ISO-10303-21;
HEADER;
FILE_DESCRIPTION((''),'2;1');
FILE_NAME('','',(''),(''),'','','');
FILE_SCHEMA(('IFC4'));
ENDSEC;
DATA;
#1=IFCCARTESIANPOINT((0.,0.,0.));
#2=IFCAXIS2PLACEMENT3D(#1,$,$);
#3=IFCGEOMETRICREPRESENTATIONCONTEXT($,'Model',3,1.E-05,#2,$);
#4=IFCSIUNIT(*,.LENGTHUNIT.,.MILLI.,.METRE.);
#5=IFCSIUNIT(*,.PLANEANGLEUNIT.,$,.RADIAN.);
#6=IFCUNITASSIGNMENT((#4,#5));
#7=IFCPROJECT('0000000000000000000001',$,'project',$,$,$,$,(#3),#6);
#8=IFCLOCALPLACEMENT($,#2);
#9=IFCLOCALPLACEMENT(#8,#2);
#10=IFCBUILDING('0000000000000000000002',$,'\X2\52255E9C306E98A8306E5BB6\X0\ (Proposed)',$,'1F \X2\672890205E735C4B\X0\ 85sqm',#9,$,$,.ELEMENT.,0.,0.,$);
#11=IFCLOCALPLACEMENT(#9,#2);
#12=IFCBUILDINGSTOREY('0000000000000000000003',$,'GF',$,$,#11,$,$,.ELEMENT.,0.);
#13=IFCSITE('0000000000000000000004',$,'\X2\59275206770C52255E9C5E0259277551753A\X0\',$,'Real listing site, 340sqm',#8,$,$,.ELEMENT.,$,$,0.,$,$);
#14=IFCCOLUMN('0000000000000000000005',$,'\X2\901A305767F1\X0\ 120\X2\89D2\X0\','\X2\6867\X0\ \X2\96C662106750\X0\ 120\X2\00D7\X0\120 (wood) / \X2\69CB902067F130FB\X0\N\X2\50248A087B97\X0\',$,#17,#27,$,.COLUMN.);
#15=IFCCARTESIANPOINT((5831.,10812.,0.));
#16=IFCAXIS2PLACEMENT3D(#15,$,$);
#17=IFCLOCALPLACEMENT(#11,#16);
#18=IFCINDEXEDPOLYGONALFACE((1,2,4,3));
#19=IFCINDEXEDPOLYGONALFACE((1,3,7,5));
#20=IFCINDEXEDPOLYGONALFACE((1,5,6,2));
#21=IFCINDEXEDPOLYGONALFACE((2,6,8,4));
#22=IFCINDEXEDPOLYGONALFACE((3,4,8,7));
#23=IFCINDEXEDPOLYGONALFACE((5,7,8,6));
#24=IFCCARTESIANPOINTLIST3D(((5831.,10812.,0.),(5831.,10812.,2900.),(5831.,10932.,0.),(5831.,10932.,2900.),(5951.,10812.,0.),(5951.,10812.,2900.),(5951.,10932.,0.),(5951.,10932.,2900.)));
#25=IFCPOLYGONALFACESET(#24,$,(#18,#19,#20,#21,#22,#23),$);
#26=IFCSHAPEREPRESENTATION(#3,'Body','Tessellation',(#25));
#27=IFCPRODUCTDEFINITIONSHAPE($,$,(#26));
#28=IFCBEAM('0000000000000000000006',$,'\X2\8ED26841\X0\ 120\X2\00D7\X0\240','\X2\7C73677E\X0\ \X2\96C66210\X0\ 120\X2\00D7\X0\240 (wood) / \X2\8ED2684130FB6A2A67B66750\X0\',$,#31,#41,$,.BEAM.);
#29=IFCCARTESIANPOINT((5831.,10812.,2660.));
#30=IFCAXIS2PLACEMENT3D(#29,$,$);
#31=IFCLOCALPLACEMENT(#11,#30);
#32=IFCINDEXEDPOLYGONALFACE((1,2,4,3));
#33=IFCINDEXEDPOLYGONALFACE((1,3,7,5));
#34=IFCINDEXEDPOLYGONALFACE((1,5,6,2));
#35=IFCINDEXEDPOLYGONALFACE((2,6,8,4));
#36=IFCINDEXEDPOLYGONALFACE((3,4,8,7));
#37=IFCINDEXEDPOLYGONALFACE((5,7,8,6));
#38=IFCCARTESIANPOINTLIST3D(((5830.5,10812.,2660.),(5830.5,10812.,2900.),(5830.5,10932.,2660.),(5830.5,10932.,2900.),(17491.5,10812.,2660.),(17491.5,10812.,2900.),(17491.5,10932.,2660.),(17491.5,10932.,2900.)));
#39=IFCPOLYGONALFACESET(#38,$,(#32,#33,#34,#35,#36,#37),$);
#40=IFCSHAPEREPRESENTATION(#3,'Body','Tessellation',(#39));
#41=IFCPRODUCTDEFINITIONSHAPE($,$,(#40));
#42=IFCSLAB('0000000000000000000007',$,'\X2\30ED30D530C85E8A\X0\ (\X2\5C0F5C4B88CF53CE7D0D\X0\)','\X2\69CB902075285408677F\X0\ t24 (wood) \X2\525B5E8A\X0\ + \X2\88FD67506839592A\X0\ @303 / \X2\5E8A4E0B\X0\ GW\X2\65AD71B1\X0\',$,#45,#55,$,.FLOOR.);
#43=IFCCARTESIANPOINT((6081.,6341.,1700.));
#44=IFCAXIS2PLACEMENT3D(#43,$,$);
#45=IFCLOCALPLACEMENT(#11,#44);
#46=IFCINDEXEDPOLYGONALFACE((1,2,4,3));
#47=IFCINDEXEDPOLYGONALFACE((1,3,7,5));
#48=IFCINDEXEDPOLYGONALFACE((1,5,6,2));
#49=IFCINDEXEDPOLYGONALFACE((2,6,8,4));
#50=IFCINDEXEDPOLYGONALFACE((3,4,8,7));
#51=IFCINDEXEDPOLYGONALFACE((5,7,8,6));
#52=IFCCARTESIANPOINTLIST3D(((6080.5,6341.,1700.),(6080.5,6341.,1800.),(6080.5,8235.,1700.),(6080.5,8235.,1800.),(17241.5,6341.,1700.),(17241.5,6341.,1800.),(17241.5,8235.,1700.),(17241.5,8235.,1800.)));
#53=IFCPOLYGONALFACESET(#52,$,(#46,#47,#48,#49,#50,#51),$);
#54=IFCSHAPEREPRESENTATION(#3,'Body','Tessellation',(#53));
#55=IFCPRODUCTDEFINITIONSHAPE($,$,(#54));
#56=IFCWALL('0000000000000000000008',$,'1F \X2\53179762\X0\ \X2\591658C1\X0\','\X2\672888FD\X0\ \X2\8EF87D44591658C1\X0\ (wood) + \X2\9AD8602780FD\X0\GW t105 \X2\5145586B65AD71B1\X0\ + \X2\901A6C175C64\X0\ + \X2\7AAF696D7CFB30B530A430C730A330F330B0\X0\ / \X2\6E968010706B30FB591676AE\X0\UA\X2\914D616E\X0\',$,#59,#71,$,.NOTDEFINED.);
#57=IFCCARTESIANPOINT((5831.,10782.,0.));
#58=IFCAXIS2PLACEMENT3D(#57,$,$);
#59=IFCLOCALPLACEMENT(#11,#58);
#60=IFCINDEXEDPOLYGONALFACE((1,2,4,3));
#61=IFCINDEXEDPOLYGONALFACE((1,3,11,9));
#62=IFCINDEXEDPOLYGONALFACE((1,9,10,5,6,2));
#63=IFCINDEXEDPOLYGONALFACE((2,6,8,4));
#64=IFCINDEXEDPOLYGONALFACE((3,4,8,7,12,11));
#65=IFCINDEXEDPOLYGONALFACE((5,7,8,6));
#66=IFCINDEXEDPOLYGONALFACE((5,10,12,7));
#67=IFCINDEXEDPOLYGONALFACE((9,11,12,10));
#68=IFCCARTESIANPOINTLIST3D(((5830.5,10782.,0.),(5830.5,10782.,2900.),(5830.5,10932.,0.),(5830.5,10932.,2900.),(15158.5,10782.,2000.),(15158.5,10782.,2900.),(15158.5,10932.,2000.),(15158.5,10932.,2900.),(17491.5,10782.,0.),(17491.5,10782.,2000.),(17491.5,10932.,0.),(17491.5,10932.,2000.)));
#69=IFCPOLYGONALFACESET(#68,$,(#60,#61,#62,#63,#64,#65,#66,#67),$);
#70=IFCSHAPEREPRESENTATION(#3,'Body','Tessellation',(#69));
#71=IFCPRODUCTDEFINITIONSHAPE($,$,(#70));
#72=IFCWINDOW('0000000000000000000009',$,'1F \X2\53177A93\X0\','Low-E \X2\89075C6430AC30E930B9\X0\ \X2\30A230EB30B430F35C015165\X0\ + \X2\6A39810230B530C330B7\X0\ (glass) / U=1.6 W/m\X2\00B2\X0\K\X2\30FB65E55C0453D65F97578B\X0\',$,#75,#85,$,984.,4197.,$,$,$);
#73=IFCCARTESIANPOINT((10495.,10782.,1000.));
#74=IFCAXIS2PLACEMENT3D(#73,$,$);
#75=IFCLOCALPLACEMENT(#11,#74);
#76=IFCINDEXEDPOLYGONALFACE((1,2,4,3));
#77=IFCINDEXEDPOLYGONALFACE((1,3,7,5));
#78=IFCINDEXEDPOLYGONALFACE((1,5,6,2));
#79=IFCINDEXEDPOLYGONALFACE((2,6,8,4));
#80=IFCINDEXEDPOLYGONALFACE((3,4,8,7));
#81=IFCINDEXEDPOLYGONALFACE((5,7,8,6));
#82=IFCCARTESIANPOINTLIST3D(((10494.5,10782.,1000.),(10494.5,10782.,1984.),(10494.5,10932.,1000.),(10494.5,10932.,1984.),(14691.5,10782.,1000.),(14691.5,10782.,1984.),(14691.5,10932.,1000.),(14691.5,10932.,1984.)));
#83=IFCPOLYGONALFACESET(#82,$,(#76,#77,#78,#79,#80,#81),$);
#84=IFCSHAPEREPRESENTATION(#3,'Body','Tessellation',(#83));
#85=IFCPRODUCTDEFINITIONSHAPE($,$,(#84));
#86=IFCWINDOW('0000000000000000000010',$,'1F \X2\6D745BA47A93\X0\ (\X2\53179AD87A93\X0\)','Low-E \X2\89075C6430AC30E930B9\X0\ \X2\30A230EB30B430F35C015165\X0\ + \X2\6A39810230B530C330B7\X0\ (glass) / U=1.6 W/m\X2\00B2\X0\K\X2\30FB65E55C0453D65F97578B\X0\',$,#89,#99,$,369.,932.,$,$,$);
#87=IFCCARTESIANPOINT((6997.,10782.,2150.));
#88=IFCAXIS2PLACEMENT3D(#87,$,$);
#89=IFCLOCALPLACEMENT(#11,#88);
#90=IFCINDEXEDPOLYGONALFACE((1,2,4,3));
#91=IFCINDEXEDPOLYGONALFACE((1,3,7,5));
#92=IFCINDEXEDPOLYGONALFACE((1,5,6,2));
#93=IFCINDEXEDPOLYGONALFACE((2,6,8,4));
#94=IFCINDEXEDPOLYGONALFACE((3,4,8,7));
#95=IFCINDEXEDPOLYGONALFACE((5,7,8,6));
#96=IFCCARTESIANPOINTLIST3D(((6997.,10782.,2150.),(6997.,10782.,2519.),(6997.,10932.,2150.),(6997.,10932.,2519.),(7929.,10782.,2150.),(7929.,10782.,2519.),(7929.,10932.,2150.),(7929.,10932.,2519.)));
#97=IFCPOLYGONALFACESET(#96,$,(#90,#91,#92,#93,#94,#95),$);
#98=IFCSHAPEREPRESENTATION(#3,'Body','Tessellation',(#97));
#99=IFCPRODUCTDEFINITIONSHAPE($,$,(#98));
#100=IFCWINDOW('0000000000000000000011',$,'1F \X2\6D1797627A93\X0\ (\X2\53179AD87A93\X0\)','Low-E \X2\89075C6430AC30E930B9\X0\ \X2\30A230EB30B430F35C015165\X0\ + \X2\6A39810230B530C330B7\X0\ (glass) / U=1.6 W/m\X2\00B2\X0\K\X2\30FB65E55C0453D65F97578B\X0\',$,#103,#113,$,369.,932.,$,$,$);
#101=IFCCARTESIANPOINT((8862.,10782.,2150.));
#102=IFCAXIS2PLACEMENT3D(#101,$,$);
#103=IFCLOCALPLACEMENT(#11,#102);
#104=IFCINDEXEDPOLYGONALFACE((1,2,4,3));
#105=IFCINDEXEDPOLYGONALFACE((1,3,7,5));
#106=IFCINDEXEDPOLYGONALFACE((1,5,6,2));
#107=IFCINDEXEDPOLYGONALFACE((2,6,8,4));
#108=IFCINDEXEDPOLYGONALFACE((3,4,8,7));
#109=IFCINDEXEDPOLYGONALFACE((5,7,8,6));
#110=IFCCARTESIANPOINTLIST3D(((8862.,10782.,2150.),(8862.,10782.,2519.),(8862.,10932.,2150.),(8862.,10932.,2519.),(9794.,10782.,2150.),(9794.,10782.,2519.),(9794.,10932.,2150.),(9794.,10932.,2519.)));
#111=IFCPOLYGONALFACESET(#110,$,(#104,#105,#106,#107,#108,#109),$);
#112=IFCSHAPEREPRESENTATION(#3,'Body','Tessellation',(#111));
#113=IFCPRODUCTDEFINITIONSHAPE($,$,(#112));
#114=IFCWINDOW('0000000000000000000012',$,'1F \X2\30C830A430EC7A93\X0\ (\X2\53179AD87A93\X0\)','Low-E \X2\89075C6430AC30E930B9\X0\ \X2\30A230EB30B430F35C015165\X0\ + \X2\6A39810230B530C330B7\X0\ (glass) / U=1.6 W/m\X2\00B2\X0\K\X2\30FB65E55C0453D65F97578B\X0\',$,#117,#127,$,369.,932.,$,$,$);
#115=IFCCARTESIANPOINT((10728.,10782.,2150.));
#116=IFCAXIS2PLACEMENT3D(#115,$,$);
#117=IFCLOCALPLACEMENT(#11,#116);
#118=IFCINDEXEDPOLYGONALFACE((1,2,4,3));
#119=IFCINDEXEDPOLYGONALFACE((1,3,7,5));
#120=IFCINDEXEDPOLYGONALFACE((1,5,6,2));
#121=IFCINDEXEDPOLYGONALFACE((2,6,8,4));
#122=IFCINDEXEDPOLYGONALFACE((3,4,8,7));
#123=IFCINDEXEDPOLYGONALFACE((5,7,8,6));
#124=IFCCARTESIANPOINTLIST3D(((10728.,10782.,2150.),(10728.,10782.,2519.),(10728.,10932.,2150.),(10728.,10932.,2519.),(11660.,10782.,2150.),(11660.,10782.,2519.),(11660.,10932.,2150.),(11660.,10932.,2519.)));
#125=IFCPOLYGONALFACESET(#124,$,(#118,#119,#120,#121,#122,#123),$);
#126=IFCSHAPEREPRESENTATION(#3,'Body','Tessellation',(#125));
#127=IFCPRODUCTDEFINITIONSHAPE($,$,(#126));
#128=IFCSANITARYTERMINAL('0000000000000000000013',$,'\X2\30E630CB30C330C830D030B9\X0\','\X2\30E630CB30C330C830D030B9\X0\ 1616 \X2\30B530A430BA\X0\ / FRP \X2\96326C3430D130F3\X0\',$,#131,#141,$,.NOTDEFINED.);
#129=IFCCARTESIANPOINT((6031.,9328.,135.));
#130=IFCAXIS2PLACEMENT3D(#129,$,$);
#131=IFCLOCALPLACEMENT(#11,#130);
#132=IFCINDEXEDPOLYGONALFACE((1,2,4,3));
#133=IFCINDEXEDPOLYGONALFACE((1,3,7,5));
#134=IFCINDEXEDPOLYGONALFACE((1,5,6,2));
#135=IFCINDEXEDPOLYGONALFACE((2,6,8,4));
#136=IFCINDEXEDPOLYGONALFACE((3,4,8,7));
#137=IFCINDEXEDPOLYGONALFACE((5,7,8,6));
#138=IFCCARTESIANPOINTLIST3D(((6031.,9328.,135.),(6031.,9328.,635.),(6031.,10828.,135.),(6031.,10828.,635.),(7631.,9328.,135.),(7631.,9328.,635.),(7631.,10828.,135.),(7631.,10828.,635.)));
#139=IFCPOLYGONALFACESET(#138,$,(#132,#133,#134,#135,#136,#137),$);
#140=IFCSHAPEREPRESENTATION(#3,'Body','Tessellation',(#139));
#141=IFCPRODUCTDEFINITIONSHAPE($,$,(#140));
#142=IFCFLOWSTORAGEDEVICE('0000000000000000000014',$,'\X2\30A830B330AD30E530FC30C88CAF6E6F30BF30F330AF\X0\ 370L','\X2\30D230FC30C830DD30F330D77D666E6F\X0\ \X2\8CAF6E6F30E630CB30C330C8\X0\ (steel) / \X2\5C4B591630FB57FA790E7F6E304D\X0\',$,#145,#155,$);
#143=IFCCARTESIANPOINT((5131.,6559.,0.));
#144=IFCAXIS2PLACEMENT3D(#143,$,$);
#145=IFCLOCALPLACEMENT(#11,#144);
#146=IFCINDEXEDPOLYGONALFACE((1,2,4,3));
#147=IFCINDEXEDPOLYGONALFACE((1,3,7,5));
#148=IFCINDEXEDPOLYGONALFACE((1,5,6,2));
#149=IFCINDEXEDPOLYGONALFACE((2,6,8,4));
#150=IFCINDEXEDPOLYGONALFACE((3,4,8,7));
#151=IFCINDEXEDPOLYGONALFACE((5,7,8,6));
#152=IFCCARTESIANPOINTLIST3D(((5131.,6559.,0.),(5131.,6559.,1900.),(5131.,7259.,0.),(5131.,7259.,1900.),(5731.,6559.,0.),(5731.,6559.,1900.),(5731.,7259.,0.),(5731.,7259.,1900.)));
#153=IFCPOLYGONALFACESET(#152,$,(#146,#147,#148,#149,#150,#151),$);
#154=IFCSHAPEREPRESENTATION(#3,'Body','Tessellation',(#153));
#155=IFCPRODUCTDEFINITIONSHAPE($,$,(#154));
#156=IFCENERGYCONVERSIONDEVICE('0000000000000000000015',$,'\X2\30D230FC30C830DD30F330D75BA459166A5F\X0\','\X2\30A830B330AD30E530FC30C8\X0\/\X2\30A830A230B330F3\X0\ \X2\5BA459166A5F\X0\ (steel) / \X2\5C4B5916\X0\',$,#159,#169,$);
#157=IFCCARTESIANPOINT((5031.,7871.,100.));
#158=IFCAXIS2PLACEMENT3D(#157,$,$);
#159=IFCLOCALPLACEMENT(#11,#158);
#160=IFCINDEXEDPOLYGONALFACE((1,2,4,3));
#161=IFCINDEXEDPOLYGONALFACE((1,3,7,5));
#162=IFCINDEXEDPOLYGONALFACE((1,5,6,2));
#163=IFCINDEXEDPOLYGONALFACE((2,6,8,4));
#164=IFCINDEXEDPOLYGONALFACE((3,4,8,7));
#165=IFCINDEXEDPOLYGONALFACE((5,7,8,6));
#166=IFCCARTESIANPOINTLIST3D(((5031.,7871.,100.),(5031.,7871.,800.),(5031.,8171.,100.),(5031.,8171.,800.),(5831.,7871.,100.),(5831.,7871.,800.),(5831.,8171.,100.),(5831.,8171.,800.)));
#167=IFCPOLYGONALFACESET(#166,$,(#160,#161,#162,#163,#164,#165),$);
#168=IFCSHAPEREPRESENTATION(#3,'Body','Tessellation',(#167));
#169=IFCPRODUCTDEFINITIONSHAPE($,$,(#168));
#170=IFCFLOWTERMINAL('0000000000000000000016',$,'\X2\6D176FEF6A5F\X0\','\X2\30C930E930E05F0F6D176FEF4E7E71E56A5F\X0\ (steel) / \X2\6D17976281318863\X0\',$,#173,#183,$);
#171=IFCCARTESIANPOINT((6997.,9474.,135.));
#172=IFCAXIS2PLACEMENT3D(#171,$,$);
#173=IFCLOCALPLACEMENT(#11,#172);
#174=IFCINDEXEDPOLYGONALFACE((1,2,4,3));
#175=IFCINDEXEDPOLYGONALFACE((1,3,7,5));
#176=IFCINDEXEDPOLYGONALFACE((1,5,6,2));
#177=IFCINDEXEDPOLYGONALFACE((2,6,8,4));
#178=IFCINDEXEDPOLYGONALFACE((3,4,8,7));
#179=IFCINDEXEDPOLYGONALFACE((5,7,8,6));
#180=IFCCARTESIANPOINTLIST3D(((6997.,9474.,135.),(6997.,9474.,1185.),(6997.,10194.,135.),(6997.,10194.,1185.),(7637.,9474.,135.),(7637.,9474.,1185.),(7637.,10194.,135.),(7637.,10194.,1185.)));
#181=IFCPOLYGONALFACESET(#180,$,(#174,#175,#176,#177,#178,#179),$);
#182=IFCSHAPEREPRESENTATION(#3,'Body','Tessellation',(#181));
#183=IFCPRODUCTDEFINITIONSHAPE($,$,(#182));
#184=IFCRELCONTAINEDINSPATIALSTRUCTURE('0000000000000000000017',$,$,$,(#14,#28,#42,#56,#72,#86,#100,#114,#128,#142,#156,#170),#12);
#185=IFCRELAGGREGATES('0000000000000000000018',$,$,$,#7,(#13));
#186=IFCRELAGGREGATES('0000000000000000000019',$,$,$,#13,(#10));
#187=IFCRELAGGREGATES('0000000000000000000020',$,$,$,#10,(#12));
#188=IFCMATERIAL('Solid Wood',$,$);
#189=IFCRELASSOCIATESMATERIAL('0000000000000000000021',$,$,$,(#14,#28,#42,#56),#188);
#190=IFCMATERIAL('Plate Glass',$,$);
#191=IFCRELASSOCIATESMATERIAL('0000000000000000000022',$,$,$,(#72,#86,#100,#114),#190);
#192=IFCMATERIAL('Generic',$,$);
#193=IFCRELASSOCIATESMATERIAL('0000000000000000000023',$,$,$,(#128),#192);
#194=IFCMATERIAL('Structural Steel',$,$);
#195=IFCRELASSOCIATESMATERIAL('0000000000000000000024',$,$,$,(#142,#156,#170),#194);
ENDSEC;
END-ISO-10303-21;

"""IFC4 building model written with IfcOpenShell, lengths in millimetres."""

from ifc_helpers import new_model, si_unit, frame, frame_2d, origin, place, context, project, spatial, rectangle, extrude, material, element, fill, save


model = new_model("IFC4")

# Units and contexts
model_context = context("Model", 3, precision=1e-05, world=origin())
ifc_project = project(units=[si_unit("LENGTHUNIT", "METRE", prefix="MILLI"), si_unit("PLANEANGLEUNIT", "RADIAN")], contexts=[model_context])

# Site, building, storey
site_placement = place(None, origin())
site = spatial("IfcSite", under=ifc_project, at=site_placement, Name="大分県別府市大畑町", ObjectType="Real listing site, 340sqm", CompositionType="ELEMENT", RefElevation=0.0)
building_placement = place(site_placement, origin())
building = spatial("IfcBuilding", under=site, at=building_placement, Name="別府の風の家 (Proposed)", ObjectType="1F 木造平屋 85sqm", CompositionType="ELEMENT", ElevationOfRefHeight=0.0, ElevationOfTerrain=0.0)
storey_placement = place(building_placement, origin())
storey = spatial("IfcBuildingStorey", under=building, at=storey_placement, Name="GF", CompositionType="ELEMENT", Elevation=0.0)

# Column
ifc_material_1 = material(Name="Solid Wood")
column_1_placement = place(storey_placement, frame((5831.0, 10812.0, 0.0)))
element("IfcColumn", 1, at=column_1_placement, inside=storey, material=ifc_material_1, Name="通し柱 120角", Description="桧 集成材 120×120 (wood) / 構造柱・N値計算", PredefinedType="COLUMN", context=model_context, shape_type="SweptSolid", body=[
    extrude(rectangle(XDim=120.0, YDim=120.0, at=frame_2d((60.0, 60.0))), frame((5831.0, 10812.0, 0.0)), (0.0, 0.0, 1.0), 2900.0),
])

# Beam
beam_1_placement = place(storey_placement, frame((5831.0, 10812.0, 2660.0)))
element("IfcBeam", 2, at=beam_1_placement, inside=storey, material=ifc_material_1, Name="軒桁 120×240", Description="米松 集成 120×240 (wood) / 軒桁・横架材", PredefinedType="BEAM", context=model_context, shape_type="SweptSolid", body=[
    extrude(rectangle(XDim=11661.0, YDim=120.0, at=frame_2d((5830.0, 60.0))), frame((5831.0, 10812.0, 2660.0)), (0.0, 0.0, 1.0), 240.0),
])

# Slab
slab_placement = place(storey_placement, frame((6081.0, 6341.0, 1700.0)))
element("IfcSlab", 3, at=slab_placement, inside=storey, material=ifc_material_1, Name="ロフト床 (小屋裏収納)", Description="構造用合板 t24 (wood) 剛床 + 製材根太 @303 / 床下 GW断熱", PredefinedType="FLOOR", context=model_context, shape_type="SweptSolid", body=[
    extrude(rectangle(XDim=11161.0, YDim=1894.0, at=frame_2d((5580.0, 947.0))), frame((6081.0, 6341.0, 1700.0)), (0.0, 0.0, 1.0), 100.0),
])

# Wall, openings, windows
wall_1_placement = place(storey_placement, frame((5831.0, 10782.0, 0.0)))
wall_1 = element("IfcWall", 4, at=wall_1_placement, inside=storey, material=ifc_material_1, Name="1F 北面 外壁", Description="木製 軸組外壁 (wood) + 高性能GW t105 充填断熱 + 通気層 + 窯業系サイディング / 準耐火・外皮UA配慮", PredefinedType="NOTDEFINED", context=model_context, shape_type="SweptSolid", body=[
    extrude(rectangle(XDim=11661.0, YDim=150.0, at=frame_2d((5830.0, 75.0))), frame((5831.0, 10782.0, 0.0)), (0.0, 0.0, 1.0), 2900.0),
])
opening_1_placement = place(storey_placement, frame((10495.0, 10782.0, 1000.0)))
opening_1 = element("IfcOpeningElement", 5, at=opening_1_placement, cuts=wall_1, PredefinedType="NOTDEFINED", context=model_context, shape_type="SweptSolid", body=[
    extrude(rectangle(XDim=4197.0, YDim=150.0, at=frame_2d((2098.0, 75.0))), frame((10495.0, 10782.0, 1000.0)), (0.0, 0.0, 1.0), 984.0),
])
opening_2_placement = place(storey_placement, frame((6997.0, 10782.0, 2150.0)))
opening_2 = element("IfcOpeningElement", 6, at=opening_2_placement, cuts=wall_1, PredefinedType="NOTDEFINED", context=model_context, shape_type="SweptSolid", body=[
    extrude(rectangle(XDim=932.0, YDim=150.0, at=frame_2d((466.0, 75.0))), frame((6997.0, 10782.0, 2150.0)), (0.0, 0.0, 1.0), 369.0),
])
opening_3_placement = place(storey_placement, frame((8862.0, 10782.0, 2150.0)))
opening_3 = element("IfcOpeningElement", 7, at=opening_3_placement, cuts=wall_1, PredefinedType="NOTDEFINED", context=model_context, shape_type="SweptSolid", body=[
    extrude(rectangle(XDim=932.0, YDim=150.0, at=frame_2d((466.0, 75.0))), frame((8862.0, 10782.0, 2150.0)), (0.0, 0.0, 1.0), 369.0),
])
opening_4_placement = place(storey_placement, frame((10728.0, 10782.0, 2150.0)))
opening_4 = element("IfcOpeningElement", 8, at=opening_4_placement, cuts=wall_1, PredefinedType="NOTDEFINED", context=model_context, shape_type="SweptSolid", body=[
    extrude(rectangle(XDim=932.0, YDim=150.0, at=frame_2d((466.0, 75.0))), frame((10728.0, 10782.0, 2150.0)), (0.0, 0.0, 1.0), 369.0),
])
ifc_material_2 = material(Name="Plate Glass")
window_1_placement = place(storey_placement, frame((10495.0, 10782.0, 1000.0)))
window_1 = element("IfcWindow", 9, at=window_1_placement, inside=storey, material=ifc_material_2, Name="1F 北窓", Description="Low-E 複層ガラス アルゴン封入 + 樹脂サッシ (glass) / U=1.6 W/m²K・日射取得型", OverallHeight=984.0, OverallWidth=4197.0, context=model_context, shape_type="SweptSolid", body=[
    extrude(rectangle(XDim=4197.0, YDim=150.0, at=frame_2d((2098.0, 75.0))), frame((10495.0, 10782.0, 1000.0)), (0.0, 0.0, 1.0), 984.0),
])
fill(opening_1, window_1)
window_2_placement = place(storey_placement, frame((6997.0, 10782.0, 2150.0)))
window_2 = element("IfcWindow", 10, at=window_2_placement, inside=storey, material=ifc_material_2, Name="1F 浴室窓 (北高窓)", Description="Low-E 複層ガラス アルゴン封入 + 樹脂サッシ (glass) / U=1.6 W/m²K・日射取得型", OverallHeight=369.0, OverallWidth=932.0, context=model_context, shape_type="SweptSolid", body=[
    extrude(rectangle(XDim=932.0, YDim=150.0, at=frame_2d((466.0, 75.0))), frame((6997.0, 10782.0, 2150.0)), (0.0, 0.0, 1.0), 369.0),
])
fill(opening_2, window_2)
window_3_placement = place(storey_placement, frame((8862.0, 10782.0, 2150.0)))
window_3 = element("IfcWindow", 11, at=window_3_placement, inside=storey, material=ifc_material_2, Name="1F 洗面窓 (北高窓)", Description="Low-E 複層ガラス アルゴン封入 + 樹脂サッシ (glass) / U=1.6 W/m²K・日射取得型", OverallHeight=369.0, OverallWidth=932.0, context=model_context, shape_type="SweptSolid", body=[
    extrude(rectangle(XDim=932.0, YDim=150.0, at=frame_2d((466.0, 75.0))), frame((8862.0, 10782.0, 2150.0)), (0.0, 0.0, 1.0), 369.0),
])
fill(opening_3, window_3)
window_4_placement = place(storey_placement, frame((10728.0, 10782.0, 2150.0)))
window_4 = element("IfcWindow", 12, at=window_4_placement, inside=storey, material=ifc_material_2, Name="1F トイレ窓 (北高窓)", Description="Low-E 複層ガラス アルゴン封入 + 樹脂サッシ (glass) / U=1.6 W/m²K・日射取得型", OverallHeight=369.0, OverallWidth=932.0, context=model_context, shape_type="SweptSolid", body=[
    extrude(rectangle(XDim=932.0, YDim=150.0, at=frame_2d((466.0, 75.0))), frame((10728.0, 10782.0, 2150.0)), (0.0, 0.0, 1.0), 369.0),
])
fill(opening_4, window_4)

# Sanitary terminal
ifc_material_3 = material(Name="Generic")
sanitary_terminal_placement = place(storey_placement, frame((6031.0, 9328.0, 135.0)))
element("IfcSanitaryTerminal", 13, at=sanitary_terminal_placement, inside=storey, material=ifc_material_3, Name="ユニットバス", Description="ユニットバス 1616 サイズ / FRP 防水パン", PredefinedType="NOTDEFINED", context=model_context, shape_type="SweptSolid", body=[
    extrude(rectangle(XDim=1600.0, YDim=1500.0, at=frame_2d((800.0, 750.0))), frame((6031.0, 9328.0, 135.0)), (0.0, 0.0, 1.0), 500.0),
])

# Flow storage device
ifc_material_4 = material(Name="Structural Steel")
flow_storage_device_placement = place(storey_placement, frame((5131.0, 6559.0, 0.0)))
element("IfcFlowStorageDevice", 14, at=flow_storage_device_placement, inside=storey, material=ifc_material_4, Name="エコキュート貯湯タンク 370L", Description="ヒートポンプ給湯 貯湯ユニット (steel) / 屋外・基礎置き", context=model_context, shape_type="SweptSolid", body=[
    extrude(rectangle(XDim=600.0, YDim=700.0, at=frame_2d((300.0, 350.0))), frame((5131.0, 6559.0, 0.0)), (0.0, 0.0, 1.0), 1900.0),
])

# Energy conversion device
energy_conversion_device_placement = place(storey_placement, frame((5031.0, 7871.0, 100.0)))
element("IfcEnergyConversionDevice", 15, at=energy_conversion_device_placement, inside=storey, material=ifc_material_4, Name="ヒートポンプ室外機", Description="エコキュート/エアコン 室外機 (steel) / 屋外", context=model_context, shape_type="SweptSolid", body=[
    extrude(rectangle(XDim=800.0, YDim=300.0, at=frame_2d((400.0, 150.0))), frame((5031.0, 7871.0, 100.0)), (0.0, 0.0, 1.0), 700.0),
])

# Flow terminal
flow_terminal_placement = place(storey_placement, frame((6997.0, 9474.0, 135.0)))
element("IfcFlowTerminal", 16, at=flow_terminal_placement, inside=storey, material=ifc_material_4, Name="洗濯機", Description="ドラム式洗濯乾燥機 (steel) / 洗面脱衣", context=model_context, shape_type="SweptSolid", body=[
    extrude(rectangle(XDim=640.0, YDim=720.0, at=frame_2d((320.0, 360.0))), frame((6997.0, 9474.0, 135.0)), (0.0, 0.0, 1.0), 1050.0),
])

save(model, "model.ifc")
